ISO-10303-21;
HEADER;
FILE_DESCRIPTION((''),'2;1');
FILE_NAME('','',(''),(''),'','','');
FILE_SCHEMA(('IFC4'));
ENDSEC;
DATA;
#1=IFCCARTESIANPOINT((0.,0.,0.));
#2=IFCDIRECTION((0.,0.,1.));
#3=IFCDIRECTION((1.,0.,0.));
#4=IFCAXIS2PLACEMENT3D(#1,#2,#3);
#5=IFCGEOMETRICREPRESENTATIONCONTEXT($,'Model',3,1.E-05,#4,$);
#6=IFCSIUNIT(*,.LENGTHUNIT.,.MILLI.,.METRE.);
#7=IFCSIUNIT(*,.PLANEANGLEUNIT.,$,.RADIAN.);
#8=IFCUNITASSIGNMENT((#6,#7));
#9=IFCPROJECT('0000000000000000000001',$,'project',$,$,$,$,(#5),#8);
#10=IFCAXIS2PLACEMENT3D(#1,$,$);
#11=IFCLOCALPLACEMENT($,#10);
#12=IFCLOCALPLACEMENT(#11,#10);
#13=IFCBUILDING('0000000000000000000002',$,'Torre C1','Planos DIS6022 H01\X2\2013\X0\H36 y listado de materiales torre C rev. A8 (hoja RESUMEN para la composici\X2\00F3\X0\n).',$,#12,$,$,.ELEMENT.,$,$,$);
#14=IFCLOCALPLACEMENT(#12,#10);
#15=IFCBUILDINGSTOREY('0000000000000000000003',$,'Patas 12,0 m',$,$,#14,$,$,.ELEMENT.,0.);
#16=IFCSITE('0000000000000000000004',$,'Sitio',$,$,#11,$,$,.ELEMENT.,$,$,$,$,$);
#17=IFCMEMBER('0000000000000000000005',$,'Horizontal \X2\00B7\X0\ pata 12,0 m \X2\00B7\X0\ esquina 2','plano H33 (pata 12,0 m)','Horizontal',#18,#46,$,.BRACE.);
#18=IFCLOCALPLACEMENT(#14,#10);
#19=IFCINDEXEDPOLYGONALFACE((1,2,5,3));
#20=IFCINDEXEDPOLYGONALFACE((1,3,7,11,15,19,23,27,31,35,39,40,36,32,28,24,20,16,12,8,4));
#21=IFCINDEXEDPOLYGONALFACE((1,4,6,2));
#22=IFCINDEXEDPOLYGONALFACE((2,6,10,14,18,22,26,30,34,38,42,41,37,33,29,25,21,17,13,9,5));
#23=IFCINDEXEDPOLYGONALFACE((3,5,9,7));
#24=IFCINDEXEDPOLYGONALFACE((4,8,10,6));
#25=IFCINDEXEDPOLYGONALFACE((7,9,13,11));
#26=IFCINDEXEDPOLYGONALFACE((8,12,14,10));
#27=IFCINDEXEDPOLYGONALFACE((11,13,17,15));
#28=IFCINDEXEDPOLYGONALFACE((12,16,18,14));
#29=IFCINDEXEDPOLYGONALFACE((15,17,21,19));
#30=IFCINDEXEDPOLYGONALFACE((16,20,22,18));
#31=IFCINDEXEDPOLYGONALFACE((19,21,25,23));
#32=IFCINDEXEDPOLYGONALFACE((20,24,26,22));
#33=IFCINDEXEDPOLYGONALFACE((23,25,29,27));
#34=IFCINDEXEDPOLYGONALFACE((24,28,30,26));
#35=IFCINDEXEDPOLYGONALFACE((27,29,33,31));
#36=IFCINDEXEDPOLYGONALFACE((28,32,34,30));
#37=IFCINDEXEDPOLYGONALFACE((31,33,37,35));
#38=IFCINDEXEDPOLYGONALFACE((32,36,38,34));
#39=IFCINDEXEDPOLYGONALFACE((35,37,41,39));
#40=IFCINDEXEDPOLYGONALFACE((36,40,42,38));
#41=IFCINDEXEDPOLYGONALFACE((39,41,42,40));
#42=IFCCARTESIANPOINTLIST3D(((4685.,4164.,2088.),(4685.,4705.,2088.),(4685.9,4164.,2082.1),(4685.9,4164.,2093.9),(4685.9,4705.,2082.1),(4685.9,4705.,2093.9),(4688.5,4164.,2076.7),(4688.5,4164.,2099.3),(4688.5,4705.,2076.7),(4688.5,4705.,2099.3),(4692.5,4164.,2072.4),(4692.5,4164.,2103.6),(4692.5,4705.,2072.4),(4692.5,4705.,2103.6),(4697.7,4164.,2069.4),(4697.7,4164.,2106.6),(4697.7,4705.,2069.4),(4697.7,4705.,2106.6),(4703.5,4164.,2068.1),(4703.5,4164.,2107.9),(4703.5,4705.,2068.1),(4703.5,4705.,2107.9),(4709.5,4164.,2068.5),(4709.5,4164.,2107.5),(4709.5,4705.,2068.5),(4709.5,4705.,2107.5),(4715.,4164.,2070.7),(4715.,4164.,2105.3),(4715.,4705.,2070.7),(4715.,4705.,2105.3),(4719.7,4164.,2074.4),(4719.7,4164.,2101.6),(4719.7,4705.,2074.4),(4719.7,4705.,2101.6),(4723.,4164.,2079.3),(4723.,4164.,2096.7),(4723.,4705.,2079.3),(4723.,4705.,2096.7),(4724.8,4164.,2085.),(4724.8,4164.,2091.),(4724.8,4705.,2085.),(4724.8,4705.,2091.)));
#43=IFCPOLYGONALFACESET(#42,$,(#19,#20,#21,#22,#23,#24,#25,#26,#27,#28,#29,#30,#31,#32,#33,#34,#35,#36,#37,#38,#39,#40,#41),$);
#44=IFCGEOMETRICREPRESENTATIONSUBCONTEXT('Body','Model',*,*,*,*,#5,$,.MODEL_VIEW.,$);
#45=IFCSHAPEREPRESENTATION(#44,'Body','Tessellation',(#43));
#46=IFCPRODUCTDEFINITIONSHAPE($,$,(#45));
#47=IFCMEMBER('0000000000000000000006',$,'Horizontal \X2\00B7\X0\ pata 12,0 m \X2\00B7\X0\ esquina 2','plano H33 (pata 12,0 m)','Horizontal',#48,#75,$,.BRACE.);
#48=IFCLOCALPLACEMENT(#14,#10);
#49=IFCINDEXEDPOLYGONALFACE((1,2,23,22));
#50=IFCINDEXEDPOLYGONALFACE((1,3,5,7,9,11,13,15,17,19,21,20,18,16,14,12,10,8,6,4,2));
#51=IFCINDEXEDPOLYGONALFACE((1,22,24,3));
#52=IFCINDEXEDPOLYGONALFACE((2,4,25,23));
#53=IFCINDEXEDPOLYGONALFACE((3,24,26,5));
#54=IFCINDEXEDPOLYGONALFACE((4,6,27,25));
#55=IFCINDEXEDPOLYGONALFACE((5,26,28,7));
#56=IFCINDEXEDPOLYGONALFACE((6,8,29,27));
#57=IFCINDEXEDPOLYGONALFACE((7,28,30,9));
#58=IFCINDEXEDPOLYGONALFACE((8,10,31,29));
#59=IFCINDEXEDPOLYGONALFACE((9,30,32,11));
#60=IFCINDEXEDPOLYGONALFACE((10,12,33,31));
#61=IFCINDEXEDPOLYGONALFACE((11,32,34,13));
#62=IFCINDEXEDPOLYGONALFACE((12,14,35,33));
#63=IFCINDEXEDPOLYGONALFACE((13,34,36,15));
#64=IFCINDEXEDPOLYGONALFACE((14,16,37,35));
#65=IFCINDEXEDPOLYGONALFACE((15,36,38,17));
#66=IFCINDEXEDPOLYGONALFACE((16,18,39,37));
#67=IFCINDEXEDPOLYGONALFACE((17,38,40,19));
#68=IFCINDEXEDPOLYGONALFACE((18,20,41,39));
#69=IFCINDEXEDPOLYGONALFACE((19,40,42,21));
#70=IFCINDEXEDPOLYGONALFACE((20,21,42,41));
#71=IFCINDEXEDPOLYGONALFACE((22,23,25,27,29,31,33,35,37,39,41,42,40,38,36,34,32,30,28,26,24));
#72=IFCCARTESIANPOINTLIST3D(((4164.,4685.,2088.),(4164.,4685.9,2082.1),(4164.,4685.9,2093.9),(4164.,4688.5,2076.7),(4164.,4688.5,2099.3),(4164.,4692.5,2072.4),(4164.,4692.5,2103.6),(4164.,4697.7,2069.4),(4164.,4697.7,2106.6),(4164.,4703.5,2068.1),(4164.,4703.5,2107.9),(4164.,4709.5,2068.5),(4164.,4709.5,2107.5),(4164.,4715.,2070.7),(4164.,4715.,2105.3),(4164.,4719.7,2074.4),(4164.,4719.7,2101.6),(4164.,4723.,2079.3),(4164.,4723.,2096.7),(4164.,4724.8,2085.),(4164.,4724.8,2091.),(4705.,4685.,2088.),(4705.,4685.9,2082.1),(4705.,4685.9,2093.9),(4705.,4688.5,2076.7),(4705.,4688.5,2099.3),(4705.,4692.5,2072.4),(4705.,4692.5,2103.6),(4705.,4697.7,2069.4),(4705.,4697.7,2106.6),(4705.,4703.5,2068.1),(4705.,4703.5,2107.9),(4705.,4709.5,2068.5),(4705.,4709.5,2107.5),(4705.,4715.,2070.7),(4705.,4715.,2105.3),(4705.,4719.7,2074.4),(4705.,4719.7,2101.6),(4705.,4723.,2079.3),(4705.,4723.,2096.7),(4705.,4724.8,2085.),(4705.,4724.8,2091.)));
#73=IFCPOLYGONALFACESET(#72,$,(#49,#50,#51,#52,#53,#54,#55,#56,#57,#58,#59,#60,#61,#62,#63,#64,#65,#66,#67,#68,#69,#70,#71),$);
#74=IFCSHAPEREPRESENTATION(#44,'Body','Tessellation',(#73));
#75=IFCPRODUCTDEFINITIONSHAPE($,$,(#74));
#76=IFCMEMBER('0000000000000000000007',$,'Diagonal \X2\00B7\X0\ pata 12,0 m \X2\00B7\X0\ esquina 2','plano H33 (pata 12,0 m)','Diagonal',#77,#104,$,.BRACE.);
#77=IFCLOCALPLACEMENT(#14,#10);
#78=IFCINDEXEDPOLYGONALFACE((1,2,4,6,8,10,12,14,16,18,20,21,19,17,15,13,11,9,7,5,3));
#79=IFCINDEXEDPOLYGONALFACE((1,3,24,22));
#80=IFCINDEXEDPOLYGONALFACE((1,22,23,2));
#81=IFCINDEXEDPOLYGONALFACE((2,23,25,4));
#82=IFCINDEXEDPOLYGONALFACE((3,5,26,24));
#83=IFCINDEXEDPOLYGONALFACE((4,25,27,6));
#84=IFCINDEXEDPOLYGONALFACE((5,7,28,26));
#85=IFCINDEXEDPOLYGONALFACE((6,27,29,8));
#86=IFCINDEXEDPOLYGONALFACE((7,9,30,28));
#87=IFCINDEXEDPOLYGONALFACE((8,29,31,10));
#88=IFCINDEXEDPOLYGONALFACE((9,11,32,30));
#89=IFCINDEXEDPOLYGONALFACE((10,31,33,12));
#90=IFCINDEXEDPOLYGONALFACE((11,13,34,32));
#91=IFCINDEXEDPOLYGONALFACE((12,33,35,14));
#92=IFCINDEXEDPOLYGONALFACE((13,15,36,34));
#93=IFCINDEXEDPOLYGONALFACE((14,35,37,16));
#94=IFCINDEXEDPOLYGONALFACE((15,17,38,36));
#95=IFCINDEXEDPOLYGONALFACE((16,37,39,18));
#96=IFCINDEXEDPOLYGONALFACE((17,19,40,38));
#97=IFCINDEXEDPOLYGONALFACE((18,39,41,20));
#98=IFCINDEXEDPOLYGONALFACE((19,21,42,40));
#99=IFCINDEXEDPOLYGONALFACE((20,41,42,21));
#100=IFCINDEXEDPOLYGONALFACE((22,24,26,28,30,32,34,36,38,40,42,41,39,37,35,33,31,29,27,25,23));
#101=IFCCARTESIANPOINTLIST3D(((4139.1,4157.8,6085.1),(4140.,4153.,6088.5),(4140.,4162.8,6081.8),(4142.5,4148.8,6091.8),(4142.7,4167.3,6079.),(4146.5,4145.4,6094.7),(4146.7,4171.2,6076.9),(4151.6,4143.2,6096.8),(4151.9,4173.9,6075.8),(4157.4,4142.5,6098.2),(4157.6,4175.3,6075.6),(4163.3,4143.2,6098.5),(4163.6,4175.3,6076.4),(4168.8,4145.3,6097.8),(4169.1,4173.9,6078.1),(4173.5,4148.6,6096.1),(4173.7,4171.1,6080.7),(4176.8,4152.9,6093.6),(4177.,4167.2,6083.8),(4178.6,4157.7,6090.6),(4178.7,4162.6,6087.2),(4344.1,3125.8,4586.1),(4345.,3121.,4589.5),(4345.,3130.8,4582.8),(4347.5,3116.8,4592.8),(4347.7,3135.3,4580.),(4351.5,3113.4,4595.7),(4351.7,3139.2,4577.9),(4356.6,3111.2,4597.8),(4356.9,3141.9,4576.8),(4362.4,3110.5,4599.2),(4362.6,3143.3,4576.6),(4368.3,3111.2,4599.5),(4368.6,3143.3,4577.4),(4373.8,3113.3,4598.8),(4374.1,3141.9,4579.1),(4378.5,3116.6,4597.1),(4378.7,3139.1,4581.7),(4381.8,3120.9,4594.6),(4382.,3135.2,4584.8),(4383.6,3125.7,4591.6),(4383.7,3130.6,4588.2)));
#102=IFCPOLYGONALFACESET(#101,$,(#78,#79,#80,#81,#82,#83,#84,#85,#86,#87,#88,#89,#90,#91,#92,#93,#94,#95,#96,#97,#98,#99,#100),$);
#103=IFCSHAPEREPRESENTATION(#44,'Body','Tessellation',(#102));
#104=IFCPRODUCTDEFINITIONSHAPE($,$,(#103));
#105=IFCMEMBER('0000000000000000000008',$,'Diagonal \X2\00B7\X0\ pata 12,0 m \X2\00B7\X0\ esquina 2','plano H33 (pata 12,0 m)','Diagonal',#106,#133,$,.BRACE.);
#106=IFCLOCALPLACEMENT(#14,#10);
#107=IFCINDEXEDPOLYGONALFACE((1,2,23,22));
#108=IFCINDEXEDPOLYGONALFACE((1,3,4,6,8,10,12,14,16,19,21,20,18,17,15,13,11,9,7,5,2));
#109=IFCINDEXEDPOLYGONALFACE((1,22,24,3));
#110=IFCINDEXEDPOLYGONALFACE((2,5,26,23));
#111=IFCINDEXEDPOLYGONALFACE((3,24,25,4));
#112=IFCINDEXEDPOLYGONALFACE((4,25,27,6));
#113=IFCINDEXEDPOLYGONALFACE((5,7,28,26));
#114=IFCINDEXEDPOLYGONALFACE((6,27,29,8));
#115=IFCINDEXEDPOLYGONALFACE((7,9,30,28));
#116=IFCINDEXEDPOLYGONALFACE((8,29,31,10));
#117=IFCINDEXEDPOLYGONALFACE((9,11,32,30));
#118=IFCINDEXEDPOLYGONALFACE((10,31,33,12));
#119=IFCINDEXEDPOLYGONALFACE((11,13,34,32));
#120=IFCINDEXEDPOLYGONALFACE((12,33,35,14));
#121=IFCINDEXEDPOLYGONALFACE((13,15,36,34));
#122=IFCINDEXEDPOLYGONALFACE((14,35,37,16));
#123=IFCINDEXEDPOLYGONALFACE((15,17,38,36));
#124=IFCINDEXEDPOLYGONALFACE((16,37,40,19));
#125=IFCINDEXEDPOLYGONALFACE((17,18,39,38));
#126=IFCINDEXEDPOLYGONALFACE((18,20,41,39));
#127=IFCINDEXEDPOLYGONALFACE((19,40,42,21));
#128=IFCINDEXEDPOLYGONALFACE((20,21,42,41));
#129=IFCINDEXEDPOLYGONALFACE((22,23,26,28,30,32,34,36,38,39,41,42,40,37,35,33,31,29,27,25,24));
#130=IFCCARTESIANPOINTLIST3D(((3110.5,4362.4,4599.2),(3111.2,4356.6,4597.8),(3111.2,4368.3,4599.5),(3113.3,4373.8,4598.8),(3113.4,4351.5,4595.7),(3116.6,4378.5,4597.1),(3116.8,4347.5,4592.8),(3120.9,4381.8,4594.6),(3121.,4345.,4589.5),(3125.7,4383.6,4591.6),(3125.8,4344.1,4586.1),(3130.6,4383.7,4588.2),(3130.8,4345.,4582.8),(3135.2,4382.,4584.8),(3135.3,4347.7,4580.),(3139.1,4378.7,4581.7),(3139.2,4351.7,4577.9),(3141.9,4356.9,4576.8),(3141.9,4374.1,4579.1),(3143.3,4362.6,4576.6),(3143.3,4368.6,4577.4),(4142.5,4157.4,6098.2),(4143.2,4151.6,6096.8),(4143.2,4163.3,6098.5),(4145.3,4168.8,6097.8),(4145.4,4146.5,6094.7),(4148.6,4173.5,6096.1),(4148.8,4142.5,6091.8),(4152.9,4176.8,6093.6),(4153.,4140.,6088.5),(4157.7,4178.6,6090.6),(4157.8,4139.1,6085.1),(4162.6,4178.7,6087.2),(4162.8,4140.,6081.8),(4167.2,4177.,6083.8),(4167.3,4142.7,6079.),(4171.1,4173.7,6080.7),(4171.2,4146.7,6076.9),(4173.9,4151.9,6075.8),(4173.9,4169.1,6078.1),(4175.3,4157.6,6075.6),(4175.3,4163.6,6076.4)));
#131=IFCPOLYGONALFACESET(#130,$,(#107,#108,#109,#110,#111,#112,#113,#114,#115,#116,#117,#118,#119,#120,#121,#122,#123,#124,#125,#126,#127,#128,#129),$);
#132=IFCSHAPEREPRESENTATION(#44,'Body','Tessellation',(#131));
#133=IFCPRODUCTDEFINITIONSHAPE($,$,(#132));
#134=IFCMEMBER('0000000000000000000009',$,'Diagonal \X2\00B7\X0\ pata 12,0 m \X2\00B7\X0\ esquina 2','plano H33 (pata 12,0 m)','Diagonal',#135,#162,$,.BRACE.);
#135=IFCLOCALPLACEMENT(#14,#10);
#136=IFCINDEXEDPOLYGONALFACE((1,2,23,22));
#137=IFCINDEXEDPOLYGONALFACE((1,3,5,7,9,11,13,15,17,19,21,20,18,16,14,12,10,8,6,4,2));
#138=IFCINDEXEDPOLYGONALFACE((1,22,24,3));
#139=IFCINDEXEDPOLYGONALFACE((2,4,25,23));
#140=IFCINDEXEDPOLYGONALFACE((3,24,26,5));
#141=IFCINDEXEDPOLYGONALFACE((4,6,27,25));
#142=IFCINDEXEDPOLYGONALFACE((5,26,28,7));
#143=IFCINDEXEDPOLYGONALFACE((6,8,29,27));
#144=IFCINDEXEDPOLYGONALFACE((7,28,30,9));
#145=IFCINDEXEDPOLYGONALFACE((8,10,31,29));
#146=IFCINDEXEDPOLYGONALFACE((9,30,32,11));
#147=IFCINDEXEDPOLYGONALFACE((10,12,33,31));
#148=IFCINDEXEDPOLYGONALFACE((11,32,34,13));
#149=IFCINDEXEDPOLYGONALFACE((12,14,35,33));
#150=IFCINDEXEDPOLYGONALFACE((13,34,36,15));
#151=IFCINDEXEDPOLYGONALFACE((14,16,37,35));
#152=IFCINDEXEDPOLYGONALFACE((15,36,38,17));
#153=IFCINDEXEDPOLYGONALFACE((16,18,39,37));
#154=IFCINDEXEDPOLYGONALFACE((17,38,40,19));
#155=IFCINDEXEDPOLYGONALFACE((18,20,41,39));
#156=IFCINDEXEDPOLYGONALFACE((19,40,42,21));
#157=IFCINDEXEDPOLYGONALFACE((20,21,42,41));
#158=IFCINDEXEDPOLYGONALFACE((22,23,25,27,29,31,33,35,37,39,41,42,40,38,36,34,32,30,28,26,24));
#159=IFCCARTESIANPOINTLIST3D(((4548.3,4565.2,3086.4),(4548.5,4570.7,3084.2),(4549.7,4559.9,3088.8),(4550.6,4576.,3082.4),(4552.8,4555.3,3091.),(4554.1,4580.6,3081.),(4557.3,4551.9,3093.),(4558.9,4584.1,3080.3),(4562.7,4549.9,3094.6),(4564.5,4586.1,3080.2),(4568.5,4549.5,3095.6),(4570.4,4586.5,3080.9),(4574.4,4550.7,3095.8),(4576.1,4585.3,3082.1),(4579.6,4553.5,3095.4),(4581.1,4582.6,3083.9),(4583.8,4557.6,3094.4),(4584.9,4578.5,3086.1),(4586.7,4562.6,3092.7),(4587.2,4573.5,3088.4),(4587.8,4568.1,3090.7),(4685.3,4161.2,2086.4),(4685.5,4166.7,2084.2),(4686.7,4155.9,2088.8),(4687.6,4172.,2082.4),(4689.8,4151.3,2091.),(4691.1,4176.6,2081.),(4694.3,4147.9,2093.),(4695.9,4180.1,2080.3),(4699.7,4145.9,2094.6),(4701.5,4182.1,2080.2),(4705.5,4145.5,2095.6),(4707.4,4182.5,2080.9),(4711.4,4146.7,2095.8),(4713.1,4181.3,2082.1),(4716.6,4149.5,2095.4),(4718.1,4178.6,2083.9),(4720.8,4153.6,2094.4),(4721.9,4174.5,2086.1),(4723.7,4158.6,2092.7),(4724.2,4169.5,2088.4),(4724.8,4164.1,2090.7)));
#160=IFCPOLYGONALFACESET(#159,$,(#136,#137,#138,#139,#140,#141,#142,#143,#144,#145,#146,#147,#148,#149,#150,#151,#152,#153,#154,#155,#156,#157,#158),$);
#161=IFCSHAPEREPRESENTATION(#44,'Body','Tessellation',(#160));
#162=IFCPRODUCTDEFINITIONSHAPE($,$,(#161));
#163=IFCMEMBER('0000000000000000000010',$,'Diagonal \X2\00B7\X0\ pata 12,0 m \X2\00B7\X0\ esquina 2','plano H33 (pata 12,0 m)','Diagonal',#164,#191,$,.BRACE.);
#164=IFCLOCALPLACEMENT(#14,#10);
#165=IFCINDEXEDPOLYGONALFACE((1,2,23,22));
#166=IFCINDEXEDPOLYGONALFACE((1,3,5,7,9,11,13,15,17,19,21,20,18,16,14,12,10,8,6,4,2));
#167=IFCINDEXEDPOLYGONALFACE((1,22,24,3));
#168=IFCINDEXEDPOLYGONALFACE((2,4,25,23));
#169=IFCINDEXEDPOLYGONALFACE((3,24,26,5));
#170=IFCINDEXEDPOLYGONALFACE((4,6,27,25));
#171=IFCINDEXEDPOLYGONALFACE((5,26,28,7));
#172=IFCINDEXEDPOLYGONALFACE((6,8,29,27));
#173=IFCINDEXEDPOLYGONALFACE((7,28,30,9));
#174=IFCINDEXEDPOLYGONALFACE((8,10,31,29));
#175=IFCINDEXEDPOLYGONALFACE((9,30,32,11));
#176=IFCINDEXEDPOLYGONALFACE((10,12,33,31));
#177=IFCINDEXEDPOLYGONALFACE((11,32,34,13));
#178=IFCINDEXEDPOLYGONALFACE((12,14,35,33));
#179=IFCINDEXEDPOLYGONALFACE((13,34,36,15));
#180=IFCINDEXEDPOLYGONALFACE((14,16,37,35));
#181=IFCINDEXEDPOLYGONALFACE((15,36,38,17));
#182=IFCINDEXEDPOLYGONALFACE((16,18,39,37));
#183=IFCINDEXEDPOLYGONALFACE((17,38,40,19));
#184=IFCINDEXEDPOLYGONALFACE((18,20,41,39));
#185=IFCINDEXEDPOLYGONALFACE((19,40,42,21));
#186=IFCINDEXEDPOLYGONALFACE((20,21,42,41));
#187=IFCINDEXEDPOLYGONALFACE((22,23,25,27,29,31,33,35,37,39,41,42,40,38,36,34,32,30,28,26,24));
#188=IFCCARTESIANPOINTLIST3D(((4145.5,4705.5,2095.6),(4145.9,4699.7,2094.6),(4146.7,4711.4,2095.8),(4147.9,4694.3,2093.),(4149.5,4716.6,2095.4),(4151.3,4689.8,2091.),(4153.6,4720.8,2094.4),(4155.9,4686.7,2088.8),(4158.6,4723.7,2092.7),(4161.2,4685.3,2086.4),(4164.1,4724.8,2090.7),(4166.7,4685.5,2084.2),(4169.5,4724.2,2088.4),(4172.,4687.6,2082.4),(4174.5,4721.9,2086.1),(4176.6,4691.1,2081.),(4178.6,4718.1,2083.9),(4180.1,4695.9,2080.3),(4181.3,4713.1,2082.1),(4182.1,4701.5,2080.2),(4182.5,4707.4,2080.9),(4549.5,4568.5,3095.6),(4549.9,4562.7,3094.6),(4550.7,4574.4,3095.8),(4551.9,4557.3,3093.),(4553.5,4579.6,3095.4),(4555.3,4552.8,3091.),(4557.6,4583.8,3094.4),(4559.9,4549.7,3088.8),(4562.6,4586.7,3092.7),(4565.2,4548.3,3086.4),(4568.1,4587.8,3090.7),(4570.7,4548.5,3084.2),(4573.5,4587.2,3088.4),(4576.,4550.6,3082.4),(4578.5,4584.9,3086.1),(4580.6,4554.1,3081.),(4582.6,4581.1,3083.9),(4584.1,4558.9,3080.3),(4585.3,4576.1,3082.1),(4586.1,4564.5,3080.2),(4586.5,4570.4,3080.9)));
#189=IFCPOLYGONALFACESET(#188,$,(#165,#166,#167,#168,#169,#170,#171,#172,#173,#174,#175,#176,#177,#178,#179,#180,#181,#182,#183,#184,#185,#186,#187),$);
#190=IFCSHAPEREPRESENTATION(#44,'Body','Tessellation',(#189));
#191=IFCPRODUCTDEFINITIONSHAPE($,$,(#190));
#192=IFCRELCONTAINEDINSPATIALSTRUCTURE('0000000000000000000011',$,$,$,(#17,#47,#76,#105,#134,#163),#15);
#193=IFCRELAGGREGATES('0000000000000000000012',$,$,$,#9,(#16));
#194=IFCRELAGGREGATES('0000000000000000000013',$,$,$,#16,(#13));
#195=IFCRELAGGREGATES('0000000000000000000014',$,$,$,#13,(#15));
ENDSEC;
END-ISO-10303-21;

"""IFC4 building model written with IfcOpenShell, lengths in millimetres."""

from ifc_helpers import new_model, si_unit, frame, origin, origin_with_axes, place, context, subcontext, project, spatial, circle, extrude, element, save


model = new_model("IFC4")

# Units and contexts
model_context = context("Model", 3, precision=1e-05, world=origin_with_axes())
body_context = subcontext(model_context, "Body", "Model", "MODEL_VIEW")
ifc_project = project(units=[si_unit("LENGTHUNIT", "METRE", prefix="MILLI"), si_unit("PLANEANGLEUNIT", "RADIAN")], contexts=[model_context])

# Site, building, storey
site_placement = place(None, origin())
site = spatial("IfcSite", under=ifc_project, at=site_placement, Name="Sitio", CompositionType="ELEMENT")
building_placement = place(site_placement, origin())
building = spatial("IfcBuilding", under=site, at=building_placement, Name="Torre C1", Description="Planos DIS6022 H01–H36 y listado de materiales torre C rev. A8 (hoja RESUMEN para la composición).", CompositionType="ELEMENT")
storey_placement = place(building_placement, origin())
storey = spatial("IfcBuildingStorey", under=building, at=storey_placement, Name="Patas 12,0 m", CompositionType="ELEMENT", Elevation=0.0)

# Members
for number, where, z_axis, x_axis, name in (
    (1, (4705.0, 4164.0, 2088.0), (0.0, 1.0, 0.0), (-1.0, 0.0, 0.0), "Horizontal · pata 12,0 m · esquina 2"),
    (2, (4164.0, 4705.0, 2088.0), (1.0, 0.0, 0.0), (0.0, -1.0, 0.0), "Horizontal · pata 12,0 m · esquina 2"),
):
    element("IfcMember", number, at=place(storey_placement, frame(where, z_axis=z_axis, x_axis=x_axis)), inside=storey, Name=name, Description="plano H33 (pata 12,0 m)", ObjectType="Horizontal", PredefinedType="BRACE", context=body_context, shape_type="SweptSolid", body=[
        extrude(circle(Radius=20.0), None, (0.0, 0.0, 1.0), 541.0),
    ])
for number, where, z_axis, x_axis, name in (
    (3, (4159.0, 4159.0, 6087.0), (0.111936, -0.563501, -0.818497), (-0.824827, -0.512049, 0.239723), "Diagonal · pata 12,0 m · esquina 2"),
    (4, (4159.0, 4159.0, 6087.0), (-0.563501, 0.111936, -0.818497), (-0.512049, -0.824827, 0.239723), "Diagonal · pata 12,0 m · esquina 2"),
):
    element("IfcMember", number, at=place(storey_placement, frame(where, z_axis=z_axis, x_axis=x_axis)), inside=storey, Name=name, Description="plano H33 (pata 12,0 m)", ObjectType="Diagonal", PredefinedType="BRACE", context=body_context, shape_type="SweptSolid", body=[
        extrude(circle(Radius=20.0), None, (0.0, 0.0, 1.0), 1831.4),
    ])
for number, where, z_axis, x_axis, name in (
    (5, (4568.0, 4568.0, 3088.0), (0.126013, -0.3716, -0.919801), (-0.758714, -0.633449, 0.15197), "Diagonal · pata 12,0 m · esquina 2"),
    (6, (4568.0, 4568.0, 3088.0), (-0.3716, 0.126013, -0.919801), (-0.633449, -0.758714, 0.15197), "Diagonal · pata 12,0 m · esquina 2"),
):
    element("IfcMember", number, at=place(storey_placement, frame(where, z_axis=z_axis, x_axis=x_axis)), inside=storey, Name=name, Description="plano H33 (pata 12,0 m)", ObjectType="Diagonal", PredefinedType="BRACE", context=body_context, shape_type="SweptSolid", body=[
        extrude(circle(Radius=20.0), None, (0.0, 0.0, 1.0), 1087.2),
    ])

save(model, "model.ifc")
